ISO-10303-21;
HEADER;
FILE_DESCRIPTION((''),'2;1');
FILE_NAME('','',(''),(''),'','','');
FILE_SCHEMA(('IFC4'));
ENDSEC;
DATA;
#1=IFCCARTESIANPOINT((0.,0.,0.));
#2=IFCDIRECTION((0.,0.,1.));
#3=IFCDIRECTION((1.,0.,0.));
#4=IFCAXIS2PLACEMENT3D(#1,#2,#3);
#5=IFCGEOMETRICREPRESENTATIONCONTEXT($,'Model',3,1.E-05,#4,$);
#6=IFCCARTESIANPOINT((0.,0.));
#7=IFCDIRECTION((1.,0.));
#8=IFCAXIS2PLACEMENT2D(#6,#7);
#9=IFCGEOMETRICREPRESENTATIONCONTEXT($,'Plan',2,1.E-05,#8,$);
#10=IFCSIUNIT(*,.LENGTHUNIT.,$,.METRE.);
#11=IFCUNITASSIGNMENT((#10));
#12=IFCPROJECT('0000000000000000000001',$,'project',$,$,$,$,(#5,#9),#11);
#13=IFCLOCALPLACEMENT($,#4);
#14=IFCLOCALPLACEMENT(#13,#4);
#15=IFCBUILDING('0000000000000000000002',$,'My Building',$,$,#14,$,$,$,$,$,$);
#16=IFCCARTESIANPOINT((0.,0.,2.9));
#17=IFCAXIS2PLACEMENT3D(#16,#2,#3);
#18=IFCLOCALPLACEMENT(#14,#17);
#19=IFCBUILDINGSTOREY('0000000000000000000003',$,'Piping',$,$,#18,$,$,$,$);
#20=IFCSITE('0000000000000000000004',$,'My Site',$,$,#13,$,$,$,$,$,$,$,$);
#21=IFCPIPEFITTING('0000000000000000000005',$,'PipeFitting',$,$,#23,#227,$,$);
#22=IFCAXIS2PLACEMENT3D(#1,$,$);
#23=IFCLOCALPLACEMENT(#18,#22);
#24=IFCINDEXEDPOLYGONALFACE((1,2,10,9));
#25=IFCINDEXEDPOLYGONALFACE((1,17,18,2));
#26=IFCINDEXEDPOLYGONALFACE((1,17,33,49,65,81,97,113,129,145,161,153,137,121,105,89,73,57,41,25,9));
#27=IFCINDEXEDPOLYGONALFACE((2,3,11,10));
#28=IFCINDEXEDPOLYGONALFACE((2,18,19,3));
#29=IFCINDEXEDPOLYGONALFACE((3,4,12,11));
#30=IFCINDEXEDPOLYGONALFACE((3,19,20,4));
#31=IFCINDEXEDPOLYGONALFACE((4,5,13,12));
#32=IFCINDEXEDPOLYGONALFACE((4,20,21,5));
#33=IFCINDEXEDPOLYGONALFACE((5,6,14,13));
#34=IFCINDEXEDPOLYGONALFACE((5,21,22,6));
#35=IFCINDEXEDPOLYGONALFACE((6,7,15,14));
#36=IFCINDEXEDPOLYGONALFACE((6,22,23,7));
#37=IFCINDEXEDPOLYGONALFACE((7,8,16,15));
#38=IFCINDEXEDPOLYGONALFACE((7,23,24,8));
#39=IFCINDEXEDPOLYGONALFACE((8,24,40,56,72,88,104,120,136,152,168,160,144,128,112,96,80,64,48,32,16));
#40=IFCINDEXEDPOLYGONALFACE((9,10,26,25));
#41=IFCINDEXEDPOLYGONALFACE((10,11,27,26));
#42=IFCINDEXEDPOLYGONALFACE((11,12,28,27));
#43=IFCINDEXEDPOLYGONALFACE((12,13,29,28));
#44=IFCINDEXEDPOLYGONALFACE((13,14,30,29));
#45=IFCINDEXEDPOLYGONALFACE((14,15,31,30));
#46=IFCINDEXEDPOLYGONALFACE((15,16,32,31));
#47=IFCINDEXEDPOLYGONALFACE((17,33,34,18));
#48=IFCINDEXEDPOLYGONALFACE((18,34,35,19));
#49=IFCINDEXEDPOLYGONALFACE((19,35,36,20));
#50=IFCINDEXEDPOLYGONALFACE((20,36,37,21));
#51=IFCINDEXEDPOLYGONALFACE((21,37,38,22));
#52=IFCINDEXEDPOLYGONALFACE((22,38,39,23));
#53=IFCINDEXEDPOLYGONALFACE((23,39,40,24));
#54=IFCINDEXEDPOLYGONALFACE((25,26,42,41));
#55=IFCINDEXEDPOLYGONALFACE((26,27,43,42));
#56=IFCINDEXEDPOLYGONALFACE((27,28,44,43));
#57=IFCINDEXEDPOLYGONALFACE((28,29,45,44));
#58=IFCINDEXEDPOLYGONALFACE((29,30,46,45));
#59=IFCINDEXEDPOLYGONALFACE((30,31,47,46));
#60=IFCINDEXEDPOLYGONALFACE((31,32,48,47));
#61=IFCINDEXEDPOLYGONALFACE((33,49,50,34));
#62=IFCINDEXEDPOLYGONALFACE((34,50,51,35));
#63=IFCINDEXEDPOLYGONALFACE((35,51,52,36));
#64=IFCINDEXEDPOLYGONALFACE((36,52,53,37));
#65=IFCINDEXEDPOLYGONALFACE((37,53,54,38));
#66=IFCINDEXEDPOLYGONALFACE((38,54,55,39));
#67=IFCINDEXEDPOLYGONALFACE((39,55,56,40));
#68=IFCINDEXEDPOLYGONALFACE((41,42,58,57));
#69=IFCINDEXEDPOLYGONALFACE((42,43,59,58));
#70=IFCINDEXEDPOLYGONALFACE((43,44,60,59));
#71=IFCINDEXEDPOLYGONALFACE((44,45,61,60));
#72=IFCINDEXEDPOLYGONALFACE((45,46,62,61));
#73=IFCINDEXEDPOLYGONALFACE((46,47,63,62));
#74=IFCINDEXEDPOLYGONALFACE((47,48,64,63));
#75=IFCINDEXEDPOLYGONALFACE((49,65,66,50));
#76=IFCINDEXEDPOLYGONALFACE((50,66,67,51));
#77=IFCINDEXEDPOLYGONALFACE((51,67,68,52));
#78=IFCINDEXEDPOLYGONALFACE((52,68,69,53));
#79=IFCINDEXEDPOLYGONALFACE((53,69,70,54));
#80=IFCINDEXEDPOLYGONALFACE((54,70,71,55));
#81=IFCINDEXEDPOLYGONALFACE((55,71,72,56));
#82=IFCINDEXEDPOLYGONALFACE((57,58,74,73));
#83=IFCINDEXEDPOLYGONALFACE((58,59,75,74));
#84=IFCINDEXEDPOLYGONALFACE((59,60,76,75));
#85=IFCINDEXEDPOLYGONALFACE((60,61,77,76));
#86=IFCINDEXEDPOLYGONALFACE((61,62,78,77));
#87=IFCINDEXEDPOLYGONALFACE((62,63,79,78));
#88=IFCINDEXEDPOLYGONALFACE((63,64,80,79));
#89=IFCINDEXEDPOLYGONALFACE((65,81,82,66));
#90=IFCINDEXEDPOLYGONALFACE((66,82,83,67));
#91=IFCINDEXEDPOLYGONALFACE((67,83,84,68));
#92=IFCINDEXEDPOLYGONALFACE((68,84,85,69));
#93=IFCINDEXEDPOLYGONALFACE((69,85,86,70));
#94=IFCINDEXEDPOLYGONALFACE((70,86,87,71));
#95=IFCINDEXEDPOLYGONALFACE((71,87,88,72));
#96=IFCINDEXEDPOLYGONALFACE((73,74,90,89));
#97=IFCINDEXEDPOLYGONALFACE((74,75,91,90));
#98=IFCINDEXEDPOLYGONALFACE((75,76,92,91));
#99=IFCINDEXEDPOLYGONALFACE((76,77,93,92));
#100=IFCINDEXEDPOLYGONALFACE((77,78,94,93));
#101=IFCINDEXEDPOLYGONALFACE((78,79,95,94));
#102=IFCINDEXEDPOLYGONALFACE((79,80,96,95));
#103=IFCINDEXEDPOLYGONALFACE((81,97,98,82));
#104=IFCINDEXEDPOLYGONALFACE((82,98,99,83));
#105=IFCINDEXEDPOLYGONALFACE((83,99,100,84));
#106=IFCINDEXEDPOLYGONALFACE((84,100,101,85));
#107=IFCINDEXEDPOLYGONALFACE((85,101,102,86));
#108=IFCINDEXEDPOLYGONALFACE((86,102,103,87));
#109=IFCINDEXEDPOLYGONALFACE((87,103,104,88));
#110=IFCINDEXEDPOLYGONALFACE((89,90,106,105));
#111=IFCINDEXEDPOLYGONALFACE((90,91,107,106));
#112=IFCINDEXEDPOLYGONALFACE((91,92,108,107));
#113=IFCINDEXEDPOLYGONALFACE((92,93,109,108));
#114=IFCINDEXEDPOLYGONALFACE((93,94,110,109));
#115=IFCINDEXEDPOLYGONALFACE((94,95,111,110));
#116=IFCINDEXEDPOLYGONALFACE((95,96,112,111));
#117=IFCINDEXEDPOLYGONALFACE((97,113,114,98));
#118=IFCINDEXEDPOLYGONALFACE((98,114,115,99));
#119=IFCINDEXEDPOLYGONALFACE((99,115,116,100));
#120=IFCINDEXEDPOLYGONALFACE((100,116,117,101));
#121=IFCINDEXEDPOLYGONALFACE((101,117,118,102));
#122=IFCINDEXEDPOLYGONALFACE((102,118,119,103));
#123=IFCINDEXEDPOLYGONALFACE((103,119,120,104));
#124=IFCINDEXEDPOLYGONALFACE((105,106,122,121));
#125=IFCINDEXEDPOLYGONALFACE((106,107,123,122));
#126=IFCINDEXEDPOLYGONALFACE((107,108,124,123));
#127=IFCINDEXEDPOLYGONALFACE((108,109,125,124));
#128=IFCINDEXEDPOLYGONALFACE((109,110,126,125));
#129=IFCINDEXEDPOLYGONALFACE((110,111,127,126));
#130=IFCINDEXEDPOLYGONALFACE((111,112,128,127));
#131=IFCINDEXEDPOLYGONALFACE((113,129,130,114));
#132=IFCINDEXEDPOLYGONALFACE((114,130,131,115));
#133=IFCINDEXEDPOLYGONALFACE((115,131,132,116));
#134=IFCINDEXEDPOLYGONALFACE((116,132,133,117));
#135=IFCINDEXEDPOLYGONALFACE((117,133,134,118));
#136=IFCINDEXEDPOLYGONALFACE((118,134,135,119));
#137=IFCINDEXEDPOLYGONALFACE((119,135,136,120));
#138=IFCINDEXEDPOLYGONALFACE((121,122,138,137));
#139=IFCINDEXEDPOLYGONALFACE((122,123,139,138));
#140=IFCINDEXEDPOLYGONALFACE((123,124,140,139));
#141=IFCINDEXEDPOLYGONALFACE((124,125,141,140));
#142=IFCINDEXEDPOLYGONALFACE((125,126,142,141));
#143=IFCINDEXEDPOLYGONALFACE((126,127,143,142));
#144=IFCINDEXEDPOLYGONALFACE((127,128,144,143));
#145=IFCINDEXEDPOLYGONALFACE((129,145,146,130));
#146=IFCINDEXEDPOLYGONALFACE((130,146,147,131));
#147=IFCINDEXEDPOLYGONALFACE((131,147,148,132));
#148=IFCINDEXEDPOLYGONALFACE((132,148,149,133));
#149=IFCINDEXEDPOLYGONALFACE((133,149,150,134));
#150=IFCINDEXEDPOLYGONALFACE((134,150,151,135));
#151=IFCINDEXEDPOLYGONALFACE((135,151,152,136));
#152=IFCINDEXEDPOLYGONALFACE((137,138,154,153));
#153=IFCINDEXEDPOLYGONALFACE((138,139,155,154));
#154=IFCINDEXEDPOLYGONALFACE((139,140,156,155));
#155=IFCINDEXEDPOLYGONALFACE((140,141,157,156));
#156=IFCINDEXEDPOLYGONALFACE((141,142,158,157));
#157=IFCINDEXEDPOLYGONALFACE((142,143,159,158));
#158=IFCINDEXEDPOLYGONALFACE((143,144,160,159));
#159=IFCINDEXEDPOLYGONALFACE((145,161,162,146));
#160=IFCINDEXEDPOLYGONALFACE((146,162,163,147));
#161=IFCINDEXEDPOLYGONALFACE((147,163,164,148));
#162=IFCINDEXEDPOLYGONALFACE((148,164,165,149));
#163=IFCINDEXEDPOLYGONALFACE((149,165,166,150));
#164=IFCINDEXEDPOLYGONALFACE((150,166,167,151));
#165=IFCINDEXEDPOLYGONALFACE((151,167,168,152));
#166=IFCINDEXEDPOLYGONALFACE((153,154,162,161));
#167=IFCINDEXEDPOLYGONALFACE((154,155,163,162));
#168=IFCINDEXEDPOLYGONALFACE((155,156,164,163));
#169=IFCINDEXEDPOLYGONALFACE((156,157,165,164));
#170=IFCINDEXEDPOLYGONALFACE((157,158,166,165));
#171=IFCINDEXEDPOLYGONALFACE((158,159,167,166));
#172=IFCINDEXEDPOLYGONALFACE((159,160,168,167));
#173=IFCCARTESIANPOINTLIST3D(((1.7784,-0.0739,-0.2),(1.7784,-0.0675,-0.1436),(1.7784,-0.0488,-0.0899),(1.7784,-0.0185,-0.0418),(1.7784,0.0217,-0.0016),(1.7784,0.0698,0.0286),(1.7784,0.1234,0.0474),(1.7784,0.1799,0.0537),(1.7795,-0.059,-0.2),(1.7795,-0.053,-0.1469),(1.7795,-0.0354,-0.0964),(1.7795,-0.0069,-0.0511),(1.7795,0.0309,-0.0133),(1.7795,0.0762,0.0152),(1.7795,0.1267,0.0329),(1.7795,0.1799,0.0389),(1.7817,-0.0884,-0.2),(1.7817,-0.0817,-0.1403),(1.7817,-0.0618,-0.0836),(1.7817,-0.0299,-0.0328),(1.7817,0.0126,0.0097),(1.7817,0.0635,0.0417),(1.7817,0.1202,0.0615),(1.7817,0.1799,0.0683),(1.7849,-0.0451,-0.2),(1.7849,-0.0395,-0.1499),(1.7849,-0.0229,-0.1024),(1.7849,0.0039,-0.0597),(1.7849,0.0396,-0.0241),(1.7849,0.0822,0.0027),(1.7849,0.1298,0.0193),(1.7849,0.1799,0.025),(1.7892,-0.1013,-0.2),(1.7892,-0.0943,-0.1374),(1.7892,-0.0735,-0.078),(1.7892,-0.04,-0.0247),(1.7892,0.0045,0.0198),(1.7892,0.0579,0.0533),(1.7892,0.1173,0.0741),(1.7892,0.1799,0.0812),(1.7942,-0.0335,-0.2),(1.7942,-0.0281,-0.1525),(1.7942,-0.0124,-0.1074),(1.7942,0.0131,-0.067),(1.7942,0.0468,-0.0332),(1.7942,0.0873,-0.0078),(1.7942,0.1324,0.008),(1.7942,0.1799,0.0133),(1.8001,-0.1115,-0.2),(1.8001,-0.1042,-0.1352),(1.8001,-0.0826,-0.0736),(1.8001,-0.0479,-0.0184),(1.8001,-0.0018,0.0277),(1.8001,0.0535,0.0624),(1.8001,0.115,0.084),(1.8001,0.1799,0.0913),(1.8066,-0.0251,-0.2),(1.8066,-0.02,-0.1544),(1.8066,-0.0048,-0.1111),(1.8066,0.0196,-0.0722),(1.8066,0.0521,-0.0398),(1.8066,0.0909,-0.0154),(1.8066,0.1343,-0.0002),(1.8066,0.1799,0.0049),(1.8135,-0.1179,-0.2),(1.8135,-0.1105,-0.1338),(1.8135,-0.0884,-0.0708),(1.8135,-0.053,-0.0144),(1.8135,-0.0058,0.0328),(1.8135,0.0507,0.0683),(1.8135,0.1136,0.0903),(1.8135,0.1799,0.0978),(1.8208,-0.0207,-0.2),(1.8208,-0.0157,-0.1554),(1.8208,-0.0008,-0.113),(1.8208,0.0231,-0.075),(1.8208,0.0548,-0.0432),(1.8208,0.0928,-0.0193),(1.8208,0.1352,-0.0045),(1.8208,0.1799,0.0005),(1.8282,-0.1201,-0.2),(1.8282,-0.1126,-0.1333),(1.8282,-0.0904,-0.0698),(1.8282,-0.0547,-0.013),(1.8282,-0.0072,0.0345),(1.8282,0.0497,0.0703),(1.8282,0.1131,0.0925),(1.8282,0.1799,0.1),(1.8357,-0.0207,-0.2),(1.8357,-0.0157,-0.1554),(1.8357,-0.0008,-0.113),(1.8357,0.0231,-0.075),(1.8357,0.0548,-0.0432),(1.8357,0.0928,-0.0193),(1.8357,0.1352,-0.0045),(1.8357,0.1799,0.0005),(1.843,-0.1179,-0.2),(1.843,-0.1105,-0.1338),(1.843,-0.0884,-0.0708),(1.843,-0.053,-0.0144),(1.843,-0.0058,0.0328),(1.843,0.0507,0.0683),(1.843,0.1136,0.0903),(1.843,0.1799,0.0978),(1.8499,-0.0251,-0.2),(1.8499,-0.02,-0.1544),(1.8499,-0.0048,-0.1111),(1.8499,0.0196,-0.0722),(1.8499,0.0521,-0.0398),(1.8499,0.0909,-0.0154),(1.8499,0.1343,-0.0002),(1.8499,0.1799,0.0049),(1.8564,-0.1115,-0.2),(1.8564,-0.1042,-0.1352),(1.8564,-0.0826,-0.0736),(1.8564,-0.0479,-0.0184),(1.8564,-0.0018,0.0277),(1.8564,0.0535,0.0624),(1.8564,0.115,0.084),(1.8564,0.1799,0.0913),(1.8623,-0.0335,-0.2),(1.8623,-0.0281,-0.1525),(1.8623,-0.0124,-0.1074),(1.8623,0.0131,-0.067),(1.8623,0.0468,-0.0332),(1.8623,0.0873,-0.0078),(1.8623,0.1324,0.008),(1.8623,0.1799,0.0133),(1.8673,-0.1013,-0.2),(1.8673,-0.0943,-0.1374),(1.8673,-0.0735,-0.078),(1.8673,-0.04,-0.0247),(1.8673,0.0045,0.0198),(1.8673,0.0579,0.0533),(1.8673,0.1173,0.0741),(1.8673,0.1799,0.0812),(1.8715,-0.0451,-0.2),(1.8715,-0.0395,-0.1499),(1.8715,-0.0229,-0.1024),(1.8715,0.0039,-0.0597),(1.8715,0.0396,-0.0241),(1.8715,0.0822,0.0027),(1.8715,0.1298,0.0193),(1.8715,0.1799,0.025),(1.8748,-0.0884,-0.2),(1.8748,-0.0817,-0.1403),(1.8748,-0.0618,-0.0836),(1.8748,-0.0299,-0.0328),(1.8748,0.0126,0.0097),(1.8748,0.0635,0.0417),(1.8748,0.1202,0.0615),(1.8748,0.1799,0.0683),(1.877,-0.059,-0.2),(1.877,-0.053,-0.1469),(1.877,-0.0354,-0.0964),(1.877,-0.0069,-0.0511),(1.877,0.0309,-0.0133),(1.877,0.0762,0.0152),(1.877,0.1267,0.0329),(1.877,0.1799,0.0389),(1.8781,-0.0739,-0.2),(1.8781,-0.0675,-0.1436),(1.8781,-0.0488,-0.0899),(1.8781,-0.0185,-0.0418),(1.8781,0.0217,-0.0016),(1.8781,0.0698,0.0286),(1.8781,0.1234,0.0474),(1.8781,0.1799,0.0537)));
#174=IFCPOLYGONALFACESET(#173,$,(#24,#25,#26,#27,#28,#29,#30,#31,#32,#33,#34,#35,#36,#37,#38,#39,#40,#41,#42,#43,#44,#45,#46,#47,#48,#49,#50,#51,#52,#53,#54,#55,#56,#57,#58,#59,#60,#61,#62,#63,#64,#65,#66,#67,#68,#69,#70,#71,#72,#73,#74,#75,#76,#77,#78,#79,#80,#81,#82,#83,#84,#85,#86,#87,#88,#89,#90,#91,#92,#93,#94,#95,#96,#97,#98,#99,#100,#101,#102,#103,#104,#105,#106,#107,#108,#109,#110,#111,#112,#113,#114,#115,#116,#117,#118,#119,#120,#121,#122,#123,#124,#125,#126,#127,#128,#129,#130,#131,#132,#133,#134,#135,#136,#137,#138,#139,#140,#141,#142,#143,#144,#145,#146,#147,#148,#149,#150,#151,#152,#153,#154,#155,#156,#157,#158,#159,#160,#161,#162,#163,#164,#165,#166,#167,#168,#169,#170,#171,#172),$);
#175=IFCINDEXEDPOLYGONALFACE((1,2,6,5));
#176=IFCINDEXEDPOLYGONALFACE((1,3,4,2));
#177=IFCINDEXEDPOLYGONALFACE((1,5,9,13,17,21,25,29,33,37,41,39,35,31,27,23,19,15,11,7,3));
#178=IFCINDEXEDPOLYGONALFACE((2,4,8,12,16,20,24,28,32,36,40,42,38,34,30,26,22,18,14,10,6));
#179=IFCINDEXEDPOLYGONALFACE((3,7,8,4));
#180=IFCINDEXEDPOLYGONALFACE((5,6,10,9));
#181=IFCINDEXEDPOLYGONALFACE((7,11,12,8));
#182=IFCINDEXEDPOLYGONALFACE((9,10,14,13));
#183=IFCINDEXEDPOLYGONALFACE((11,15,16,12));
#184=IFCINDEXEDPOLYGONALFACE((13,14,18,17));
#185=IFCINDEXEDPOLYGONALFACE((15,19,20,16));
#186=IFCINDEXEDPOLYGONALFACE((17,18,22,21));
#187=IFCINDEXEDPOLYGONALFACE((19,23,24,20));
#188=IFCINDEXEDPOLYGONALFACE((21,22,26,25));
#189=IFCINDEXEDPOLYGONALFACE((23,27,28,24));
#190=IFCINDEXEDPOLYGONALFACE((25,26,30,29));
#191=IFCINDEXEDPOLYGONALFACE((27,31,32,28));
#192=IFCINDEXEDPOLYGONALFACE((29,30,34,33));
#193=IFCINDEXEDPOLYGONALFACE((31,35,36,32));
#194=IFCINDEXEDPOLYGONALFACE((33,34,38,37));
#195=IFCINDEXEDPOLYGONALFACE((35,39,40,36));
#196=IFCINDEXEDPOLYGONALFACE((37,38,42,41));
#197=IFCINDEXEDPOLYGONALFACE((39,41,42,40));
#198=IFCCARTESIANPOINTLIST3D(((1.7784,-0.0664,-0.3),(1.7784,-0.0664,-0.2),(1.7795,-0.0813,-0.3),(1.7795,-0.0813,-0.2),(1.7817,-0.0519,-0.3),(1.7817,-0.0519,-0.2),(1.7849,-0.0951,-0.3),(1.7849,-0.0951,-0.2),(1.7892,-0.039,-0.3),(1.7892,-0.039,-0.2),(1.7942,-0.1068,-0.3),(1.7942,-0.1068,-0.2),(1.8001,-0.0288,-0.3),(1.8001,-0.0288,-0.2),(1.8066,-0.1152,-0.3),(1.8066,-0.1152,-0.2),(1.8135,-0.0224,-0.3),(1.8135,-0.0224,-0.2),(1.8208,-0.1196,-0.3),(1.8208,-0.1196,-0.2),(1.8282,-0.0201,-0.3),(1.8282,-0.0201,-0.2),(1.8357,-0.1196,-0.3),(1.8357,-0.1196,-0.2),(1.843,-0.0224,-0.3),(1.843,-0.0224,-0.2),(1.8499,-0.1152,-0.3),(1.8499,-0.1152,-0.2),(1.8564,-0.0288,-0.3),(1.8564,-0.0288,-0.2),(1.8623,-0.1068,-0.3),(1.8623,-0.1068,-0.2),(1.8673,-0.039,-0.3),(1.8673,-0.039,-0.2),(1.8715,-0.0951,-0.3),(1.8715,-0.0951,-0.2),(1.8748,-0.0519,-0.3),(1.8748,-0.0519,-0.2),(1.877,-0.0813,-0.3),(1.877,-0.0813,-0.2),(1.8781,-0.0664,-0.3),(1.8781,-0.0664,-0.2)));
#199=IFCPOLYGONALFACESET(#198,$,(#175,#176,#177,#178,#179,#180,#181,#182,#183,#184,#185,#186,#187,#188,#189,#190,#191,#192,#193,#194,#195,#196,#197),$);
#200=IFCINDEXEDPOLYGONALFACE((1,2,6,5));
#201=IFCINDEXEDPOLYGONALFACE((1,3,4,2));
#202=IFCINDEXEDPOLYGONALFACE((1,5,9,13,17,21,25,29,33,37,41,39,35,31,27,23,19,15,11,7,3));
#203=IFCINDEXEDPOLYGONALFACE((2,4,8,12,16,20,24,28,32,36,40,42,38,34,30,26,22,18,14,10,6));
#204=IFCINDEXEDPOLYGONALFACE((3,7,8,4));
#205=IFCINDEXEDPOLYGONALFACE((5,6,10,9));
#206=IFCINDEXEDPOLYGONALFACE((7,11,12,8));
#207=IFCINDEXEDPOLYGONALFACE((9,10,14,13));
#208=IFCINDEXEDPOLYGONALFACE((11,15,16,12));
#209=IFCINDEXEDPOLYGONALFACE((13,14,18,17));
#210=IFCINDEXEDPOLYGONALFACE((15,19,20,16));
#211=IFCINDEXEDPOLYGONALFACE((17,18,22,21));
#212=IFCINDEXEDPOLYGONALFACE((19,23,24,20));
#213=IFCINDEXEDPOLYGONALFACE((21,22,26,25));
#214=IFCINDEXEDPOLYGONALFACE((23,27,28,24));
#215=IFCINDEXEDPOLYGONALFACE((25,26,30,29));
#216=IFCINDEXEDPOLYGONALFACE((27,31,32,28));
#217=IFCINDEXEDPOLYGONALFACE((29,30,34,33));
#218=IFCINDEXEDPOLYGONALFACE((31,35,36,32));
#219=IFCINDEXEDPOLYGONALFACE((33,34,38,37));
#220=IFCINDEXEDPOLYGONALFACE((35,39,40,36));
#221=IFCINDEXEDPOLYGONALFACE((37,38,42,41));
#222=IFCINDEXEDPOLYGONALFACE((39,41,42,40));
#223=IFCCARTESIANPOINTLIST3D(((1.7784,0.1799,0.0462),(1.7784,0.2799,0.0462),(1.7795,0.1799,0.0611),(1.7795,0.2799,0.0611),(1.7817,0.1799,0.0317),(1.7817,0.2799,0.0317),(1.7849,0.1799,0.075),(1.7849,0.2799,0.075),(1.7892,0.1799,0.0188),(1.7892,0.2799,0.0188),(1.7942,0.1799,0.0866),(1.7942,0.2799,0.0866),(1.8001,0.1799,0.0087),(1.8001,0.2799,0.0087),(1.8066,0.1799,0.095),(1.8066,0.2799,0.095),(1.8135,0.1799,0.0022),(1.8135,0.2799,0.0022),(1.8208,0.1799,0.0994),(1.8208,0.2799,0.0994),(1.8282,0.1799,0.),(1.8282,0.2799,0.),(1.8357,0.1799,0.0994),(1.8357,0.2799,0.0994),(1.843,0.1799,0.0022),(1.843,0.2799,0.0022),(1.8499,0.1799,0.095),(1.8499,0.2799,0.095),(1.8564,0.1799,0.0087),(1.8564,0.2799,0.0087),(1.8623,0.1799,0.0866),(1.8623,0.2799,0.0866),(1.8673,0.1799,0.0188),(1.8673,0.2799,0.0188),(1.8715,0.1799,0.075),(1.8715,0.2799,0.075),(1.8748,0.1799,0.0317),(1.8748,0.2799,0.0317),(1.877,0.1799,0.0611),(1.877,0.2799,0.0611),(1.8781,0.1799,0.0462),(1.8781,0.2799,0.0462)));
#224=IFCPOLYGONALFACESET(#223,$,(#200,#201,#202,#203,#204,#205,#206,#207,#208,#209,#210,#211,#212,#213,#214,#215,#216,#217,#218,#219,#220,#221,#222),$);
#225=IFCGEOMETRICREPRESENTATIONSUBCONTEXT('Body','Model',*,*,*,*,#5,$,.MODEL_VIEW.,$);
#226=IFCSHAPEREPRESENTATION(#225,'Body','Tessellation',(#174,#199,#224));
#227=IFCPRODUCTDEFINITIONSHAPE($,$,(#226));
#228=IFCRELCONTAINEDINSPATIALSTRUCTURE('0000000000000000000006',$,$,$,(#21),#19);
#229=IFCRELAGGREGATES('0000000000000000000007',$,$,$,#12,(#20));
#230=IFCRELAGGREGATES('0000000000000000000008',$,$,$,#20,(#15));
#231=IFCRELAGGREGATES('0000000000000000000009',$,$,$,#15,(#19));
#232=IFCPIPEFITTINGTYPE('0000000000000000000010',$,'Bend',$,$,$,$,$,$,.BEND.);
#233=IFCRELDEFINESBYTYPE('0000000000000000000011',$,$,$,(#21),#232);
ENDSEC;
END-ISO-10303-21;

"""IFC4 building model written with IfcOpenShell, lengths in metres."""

from ifc_helpers import new_model, entity, si_unit, frame, origin_with_axes, origin_2d_with_axis, place, context, subcontext, project, spatial, circle, extrude, source, transform, mapped, type_object, type_shapes, element, save


model = new_model("IFC4")

# Units and contexts
model_context = context("Model", 3, precision=1e-05, world=origin_with_axes())
plan_context = context("Plan", 2, precision=1e-05, world=origin_2d_with_axis())
body_context = subcontext(model_context, "Body", "Model", "MODEL_VIEW")
ifc_project = project(units=[si_unit("LENGTHUNIT", "METRE")], contexts=[model_context, plan_context])

# Site, building, storey
site_placement = place(None, origin_with_axes())
site = spatial("IfcSite", under=ifc_project, at=site_placement, Name="My Site")
building_placement = place(site_placement, origin_with_axes())
building = spatial("IfcBuilding", under=site, at=building_placement, Name="My Building")
storey_placement = place(building_placement, frame((0.0, 0.0, 2.9), z_axis=(0.0, 0.0, 1.0), x_axis=(1.0, 0.0, 0.0)))
storey = spatial("IfcBuildingStorey", under=building, at=storey_placement, Name="Piping")

# Pipe fitting
pipe_fitting_type_1 = type_object("IfcPipeFittingType", Name="Bend", PredefinedType="BEND")
shared_shape = source(origin_with_axes(), body_context, "Body", "SolidModel", [
    entity("IfcSweptDiskSolid", entity("IfcIndexedPolyCurve", entity("IfcCartesianPointList3D", [[0.0, 0.0, -0.1], [0.0732, 0.0, -0.2768], [0.25, 0.0, -0.35]]), [entity("IfcArcIndex", [1, 2, 3])]), 0.05),
    extrude(circle(Radius=0.05), origin_with_axes(), (0.0, 0.0, -1.0), 0.1),
    extrude(circle(Radius=0.05), frame((0.25, 0.0, -0.35), z_axis=(1.0, 0.0, 0.0), x_axis=(0.0, 0.0, 1.0)), (0.0, 0.0, 1.0), 0.1),
])
type_shapes(pipe_fitting_type_1, [shared_shape])
for number, where, z_axis, x_axis, name in (
    (1, (1.8282, -0.0701, -0.3), (0.0, 0.0, -1.0), (0.0, 1.0, 0.0), "PipeFitting"),
):
    element("IfcPipeFitting", number, at=place(storey_placement, frame(where, z_axis=z_axis, x_axis=x_axis)), inside=storey, type_object=pipe_fitting_type_1, Name=name, context=body_context, shape_type="MappedRepresentation", body=[
        mapped(shared_shape, transform((0.0, 0.0, 0.0), x_axis=(1.0, 0.0, 0.0), y_axis=(0.0, 1.0, 0.0), z_axis=(0.0, 0.0, 1.0), scale=1.0)),
    ])

save(model, "model.ifc")
